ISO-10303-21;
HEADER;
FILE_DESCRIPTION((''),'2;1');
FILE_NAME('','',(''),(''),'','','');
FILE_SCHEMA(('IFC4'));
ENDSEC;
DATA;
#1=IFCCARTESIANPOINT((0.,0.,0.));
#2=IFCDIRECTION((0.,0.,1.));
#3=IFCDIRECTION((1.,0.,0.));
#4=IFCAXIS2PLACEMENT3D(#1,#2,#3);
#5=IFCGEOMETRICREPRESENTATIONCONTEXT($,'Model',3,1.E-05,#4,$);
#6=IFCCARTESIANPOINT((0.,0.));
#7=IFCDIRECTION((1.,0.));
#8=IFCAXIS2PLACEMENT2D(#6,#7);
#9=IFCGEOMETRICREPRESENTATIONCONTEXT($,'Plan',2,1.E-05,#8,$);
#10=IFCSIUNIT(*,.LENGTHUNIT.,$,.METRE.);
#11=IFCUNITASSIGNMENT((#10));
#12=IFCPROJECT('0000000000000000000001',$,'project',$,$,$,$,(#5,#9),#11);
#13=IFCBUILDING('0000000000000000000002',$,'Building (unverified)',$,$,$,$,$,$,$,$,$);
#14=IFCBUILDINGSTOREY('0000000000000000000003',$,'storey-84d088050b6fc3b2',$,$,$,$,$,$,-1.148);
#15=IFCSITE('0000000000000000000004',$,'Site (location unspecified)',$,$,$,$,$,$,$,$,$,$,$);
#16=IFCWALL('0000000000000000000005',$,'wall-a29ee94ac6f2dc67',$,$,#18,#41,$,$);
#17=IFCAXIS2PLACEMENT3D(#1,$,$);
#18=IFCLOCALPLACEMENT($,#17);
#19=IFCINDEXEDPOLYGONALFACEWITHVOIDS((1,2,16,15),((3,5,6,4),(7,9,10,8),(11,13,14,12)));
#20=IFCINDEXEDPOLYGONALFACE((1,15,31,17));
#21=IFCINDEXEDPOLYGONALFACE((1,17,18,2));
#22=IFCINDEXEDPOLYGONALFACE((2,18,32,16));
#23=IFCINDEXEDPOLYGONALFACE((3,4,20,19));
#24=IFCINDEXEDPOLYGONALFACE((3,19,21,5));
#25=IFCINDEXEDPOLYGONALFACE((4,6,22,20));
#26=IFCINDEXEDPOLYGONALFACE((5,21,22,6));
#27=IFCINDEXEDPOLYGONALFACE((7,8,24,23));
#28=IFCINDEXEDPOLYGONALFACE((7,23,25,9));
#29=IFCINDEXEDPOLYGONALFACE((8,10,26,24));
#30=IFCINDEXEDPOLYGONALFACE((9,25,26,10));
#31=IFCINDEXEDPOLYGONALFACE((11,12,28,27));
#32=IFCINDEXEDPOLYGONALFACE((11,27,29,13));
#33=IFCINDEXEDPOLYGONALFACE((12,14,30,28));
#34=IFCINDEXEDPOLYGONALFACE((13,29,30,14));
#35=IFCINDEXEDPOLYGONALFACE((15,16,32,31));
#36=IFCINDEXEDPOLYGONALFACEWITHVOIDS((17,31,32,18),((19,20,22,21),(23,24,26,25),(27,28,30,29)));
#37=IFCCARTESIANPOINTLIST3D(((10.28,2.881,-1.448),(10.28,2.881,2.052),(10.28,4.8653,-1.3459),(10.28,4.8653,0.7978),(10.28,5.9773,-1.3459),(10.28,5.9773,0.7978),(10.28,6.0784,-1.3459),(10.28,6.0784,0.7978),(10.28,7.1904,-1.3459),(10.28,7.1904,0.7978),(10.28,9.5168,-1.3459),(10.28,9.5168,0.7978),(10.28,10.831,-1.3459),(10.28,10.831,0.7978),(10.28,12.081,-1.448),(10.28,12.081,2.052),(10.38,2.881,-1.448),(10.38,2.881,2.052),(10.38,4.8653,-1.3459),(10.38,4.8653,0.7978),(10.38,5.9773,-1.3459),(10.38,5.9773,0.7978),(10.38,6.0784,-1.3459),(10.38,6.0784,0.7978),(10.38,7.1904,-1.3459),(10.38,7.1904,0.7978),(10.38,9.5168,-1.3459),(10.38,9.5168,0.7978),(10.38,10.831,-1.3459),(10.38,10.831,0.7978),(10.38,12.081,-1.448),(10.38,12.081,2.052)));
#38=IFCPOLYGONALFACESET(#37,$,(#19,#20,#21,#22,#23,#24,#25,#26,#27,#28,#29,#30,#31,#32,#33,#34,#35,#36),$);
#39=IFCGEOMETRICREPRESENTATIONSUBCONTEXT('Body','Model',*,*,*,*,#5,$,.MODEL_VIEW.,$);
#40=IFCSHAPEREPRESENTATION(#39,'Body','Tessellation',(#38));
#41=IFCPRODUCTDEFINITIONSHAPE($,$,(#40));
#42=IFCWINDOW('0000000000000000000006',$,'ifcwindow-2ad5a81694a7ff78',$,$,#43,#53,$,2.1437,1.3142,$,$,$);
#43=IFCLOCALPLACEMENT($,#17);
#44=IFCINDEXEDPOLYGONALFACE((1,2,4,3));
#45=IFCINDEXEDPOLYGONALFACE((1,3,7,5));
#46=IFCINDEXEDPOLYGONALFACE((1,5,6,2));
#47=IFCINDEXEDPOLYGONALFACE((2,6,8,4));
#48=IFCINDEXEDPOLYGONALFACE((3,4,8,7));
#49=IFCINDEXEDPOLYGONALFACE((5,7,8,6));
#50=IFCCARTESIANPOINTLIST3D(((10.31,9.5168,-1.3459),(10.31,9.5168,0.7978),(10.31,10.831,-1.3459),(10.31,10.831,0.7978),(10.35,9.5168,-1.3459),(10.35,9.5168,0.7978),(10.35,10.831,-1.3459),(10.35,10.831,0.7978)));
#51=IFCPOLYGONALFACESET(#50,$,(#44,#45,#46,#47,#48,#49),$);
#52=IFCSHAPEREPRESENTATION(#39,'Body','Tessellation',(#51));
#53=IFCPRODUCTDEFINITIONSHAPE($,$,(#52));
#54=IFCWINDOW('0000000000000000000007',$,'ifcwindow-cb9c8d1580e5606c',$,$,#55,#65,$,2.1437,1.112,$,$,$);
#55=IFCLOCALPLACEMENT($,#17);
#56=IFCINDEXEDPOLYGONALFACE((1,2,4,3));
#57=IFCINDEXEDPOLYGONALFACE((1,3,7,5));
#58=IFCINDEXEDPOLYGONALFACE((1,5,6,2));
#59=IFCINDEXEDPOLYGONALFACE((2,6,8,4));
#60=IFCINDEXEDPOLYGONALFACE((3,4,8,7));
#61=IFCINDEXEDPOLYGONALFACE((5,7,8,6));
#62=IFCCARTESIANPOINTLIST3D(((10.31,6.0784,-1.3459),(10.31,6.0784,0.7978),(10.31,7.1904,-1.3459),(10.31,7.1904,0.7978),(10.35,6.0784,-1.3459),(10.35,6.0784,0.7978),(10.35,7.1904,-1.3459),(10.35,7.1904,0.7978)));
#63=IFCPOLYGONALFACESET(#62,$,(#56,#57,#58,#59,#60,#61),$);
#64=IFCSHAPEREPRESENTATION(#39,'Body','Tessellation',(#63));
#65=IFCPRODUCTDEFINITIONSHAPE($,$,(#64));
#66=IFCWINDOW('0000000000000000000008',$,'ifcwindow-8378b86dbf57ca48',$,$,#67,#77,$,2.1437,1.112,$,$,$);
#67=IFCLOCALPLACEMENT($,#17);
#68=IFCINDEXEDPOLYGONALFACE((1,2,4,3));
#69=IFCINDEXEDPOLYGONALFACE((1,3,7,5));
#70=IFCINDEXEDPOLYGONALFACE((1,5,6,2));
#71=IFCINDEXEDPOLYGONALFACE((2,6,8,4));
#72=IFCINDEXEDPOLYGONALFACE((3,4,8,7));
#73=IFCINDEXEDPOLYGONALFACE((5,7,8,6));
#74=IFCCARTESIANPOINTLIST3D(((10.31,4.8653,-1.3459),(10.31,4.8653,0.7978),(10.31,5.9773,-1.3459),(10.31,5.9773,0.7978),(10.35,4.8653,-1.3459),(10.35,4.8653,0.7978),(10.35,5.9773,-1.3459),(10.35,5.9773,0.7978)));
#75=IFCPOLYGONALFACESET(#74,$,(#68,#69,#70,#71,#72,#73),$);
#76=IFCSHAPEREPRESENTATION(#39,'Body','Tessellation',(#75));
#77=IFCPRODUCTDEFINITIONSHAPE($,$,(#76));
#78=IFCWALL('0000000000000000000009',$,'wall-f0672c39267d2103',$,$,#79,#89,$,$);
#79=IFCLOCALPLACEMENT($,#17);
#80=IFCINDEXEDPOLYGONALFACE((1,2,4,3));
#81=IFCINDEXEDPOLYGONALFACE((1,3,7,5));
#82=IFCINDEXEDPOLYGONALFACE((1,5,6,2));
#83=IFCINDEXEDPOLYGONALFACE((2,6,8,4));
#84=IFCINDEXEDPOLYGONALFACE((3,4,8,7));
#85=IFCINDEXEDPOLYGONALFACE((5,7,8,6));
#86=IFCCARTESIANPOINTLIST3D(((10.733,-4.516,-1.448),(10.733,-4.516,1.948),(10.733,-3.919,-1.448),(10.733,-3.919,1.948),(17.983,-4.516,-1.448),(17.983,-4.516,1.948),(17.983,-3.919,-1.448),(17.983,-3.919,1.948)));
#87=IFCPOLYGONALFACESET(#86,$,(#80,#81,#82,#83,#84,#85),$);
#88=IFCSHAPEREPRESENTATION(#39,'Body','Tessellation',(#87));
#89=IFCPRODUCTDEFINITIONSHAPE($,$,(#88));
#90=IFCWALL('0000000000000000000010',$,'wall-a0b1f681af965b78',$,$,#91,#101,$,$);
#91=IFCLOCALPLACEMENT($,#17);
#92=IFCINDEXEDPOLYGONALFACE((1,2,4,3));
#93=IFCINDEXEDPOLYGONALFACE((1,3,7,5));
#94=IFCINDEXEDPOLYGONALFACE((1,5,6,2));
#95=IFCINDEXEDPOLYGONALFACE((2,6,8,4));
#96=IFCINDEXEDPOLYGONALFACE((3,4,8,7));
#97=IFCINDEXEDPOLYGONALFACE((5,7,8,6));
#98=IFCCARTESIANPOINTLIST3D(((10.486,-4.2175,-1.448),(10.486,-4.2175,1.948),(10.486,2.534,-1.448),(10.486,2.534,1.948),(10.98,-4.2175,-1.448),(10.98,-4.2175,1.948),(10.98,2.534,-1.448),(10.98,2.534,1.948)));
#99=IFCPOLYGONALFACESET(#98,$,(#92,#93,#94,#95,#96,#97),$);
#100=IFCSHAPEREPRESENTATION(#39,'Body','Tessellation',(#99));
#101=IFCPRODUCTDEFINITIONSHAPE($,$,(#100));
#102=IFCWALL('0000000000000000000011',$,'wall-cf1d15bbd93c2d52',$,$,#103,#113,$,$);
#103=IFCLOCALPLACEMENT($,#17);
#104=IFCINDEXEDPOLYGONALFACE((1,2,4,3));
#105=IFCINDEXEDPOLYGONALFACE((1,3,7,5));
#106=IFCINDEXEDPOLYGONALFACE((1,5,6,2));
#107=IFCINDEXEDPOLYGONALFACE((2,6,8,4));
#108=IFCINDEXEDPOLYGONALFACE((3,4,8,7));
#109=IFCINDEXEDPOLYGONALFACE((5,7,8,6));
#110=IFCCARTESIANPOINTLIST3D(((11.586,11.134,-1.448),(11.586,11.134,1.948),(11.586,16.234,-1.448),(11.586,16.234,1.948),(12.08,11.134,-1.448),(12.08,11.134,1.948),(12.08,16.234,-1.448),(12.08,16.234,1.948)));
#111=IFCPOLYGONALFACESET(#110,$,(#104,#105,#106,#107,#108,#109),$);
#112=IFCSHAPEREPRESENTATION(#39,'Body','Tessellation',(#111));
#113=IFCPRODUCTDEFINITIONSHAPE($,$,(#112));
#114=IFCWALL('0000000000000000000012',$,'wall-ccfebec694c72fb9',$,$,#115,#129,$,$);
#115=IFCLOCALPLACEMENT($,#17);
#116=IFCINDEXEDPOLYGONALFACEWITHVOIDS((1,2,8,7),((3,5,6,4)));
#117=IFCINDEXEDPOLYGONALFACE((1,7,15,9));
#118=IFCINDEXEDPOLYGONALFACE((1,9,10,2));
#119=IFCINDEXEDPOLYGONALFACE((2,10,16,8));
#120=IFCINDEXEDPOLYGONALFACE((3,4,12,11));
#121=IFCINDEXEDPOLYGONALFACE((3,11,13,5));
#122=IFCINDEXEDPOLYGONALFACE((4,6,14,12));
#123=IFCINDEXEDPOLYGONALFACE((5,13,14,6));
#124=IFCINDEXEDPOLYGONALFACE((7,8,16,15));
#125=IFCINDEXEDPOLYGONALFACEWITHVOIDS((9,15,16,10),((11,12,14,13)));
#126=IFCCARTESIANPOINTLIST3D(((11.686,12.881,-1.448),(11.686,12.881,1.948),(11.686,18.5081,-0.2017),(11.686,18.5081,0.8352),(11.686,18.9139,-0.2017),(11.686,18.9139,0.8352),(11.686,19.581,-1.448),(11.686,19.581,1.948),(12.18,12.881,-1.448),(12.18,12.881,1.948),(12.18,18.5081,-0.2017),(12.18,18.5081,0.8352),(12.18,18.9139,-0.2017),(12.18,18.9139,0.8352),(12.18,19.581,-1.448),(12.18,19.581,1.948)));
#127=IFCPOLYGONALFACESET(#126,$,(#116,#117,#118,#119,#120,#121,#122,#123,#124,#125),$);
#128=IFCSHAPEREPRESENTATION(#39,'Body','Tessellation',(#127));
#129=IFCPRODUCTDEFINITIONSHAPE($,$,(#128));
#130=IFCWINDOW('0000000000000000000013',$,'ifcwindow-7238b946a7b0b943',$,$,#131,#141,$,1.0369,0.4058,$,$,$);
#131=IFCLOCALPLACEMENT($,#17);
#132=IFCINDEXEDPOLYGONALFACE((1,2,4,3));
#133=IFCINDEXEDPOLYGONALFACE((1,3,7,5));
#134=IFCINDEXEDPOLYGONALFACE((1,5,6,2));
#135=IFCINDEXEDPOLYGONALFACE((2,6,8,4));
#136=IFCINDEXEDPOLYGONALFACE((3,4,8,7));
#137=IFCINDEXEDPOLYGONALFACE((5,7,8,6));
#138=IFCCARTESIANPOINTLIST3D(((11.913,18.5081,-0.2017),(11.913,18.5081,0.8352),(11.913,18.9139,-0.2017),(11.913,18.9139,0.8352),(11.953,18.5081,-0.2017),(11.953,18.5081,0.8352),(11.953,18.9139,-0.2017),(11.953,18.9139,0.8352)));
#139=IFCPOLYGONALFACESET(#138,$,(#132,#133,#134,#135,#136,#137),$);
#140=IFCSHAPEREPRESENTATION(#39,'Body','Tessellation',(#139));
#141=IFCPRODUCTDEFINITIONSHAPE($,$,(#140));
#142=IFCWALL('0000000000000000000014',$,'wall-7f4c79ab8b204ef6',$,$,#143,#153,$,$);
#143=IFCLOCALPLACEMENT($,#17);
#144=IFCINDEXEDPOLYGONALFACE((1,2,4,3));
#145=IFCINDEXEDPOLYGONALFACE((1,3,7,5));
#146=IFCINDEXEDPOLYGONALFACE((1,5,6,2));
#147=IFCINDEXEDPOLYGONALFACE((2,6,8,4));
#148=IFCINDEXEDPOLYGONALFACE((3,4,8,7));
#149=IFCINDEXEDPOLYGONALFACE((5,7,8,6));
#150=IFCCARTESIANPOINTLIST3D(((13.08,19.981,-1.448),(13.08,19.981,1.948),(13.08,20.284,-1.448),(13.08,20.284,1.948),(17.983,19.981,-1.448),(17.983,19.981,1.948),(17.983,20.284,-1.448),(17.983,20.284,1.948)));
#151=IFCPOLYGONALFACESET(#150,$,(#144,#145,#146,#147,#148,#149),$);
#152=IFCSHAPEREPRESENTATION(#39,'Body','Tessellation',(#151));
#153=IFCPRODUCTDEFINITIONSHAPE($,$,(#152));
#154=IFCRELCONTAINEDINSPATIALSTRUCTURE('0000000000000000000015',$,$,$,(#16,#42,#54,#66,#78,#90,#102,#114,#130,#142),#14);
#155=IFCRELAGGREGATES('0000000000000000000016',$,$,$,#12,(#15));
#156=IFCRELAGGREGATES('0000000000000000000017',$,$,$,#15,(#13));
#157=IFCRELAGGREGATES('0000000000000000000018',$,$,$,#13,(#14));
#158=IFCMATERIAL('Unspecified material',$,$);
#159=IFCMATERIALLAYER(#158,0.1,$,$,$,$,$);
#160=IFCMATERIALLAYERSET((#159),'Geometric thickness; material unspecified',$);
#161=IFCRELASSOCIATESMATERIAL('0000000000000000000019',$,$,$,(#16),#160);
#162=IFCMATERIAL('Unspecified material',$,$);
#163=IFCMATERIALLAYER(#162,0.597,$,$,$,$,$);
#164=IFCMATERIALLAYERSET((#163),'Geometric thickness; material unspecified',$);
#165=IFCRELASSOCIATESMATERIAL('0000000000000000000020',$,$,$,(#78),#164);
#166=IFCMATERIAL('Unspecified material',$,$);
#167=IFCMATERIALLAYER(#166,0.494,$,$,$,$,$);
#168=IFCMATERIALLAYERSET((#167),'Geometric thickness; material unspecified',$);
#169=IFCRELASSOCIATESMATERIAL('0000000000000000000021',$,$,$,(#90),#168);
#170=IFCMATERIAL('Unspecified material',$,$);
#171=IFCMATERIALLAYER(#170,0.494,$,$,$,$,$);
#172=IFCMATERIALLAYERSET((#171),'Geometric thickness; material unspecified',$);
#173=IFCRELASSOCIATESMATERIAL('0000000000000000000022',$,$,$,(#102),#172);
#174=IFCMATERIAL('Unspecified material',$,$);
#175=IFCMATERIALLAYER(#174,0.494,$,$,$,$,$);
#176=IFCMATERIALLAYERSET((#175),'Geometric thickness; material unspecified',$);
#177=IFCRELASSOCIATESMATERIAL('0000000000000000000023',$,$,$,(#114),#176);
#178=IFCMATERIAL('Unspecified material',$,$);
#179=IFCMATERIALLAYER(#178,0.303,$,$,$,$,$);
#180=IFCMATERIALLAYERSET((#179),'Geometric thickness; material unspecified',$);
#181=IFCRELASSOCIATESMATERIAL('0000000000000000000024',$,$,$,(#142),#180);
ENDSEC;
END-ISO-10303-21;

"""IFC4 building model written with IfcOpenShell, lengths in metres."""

from ifc_helpers import new_model, si_unit, frame, origin_with_axes, origin_2d_with_axis, place, context, subcontext, project, spatial, indexed_curve, outline, extrude, material, layer, layer_set, layer_usage, element, fill, save


model = new_model("IFC4")

# Units and contexts
model_context = context("Model", 3, precision=1e-05, world=origin_with_axes())
plan_context = context("Plan", 2, precision=1e-05, world=origin_2d_with_axis())
body_context = subcontext(model_context, "Body", "Model", "MODEL_VIEW")
ifc_project = project(units=[si_unit("LENGTHUNIT", "METRE")], contexts=[model_context, plan_context])

# Site, building, storey
site = spatial("IfcSite", under=ifc_project, Name="Site (location unspecified)")
building = spatial("IfcBuilding", under=site, Name="Building (unverified)")
storey = spatial("IfcBuildingStorey", under=building, Name="storey-84d088050b6fc3b2", Elevation=-1.148)

# Wall, openings, windows
ifc_material_1 = material(Name="Unspecified material")
ifc_layer_1 = layer(ifc_material_1, 0.1)
ifc_layer_set_1 = layer_set([ifc_layer_1], Name="Geometric thickness; material unspecified")
ifc_layer_usage_1 = layer_usage(ifc_layer_set_1, "AXIS2", "POSITIVE", -0.05)
wall_1_placement = place(None, frame((10.33, 12.081, -1.448), z_axis=(0.0, 0.0, 1.0), x_axis=(0.0, -1.0, 0.0)))
wall_1 = element("IfcWall", 1, at=wall_1_placement, inside=storey, material=ifc_layer_usage_1, Name="wall-a29ee94ac6f2dc67", context=body_context, shape_type="SweptSolid", body=[
    extrude(outline(indexed_curve([(0.0, 0.0), (0.0, 0.1), (9.2, 0.1), (9.2, 0.0), (0.0, 0.0)], self_intersect=False)), frame((0.0, -0.05, 0.0), z_axis=(0.0, 0.0, 1.0), x_axis=(1.0, 0.0, 0.0)), (0.0, 0.0, 1.0), 3.5),
])
opening_1_placement = place(wall_1_placement, frame((1.25, -0.06, 0.1021), z_axis=(0.0, 0.0, 1.0), x_axis=(1.0, 0.0, 0.0)))
opening_1 = element("IfcOpeningElement", 2, at=opening_1_placement, cuts=wall_1, context=body_context, shape_type="SweptSolid", body=[
    extrude(outline(indexed_curve([(0.0, 0.0), (0.0, 0.12), (1.3142, 0.12), (1.3142, 0.0), (0.0, 0.0)], self_intersect=False)), origin_with_axes(), (0.0, 0.0, 1.0), 2.1437),
])
opening_2_placement = place(wall_1_placement, frame((4.8906, -0.06, 0.1021), z_axis=(0.0, 0.0, 1.0), x_axis=(1.0, 0.0, 0.0)))
opening_2 = element("IfcOpeningElement", 3, at=opening_2_placement, cuts=wall_1, context=body_context, shape_type="SweptSolid", body=[
    extrude(outline(indexed_curve([(0.0, 0.0), (0.0, 0.12), (1.112, 0.12), (1.112, 0.0), (0.0, 0.0)], self_intersect=False)), origin_with_axes(), (0.0, 0.0, 1.0), 2.1437),
])
opening_3_placement = place(wall_1_placement, frame((6.1037, -0.06, 0.1021), z_axis=(0.0, 0.0, 1.0), x_axis=(1.0, 0.0, 0.0)))
opening_3 = element("IfcOpeningElement", 4, at=opening_3_placement, cuts=wall_1, context=body_context, shape_type="SweptSolid", body=[
    extrude(outline(indexed_curve([(0.0, 0.0), (0.0, 0.12), (1.112, 0.12), (1.112, 0.0), (0.0, 0.0)], self_intersect=False)), origin_with_axes(), (0.0, 0.0, 1.0), 2.1437),
])
window_1_placement = place(None, frame((10.31, 10.831, -1.3459), z_axis=(0.0, 0.0, 1.0), x_axis=(0.0, -1.0, 0.0)))
window_1 = element("IfcWindow", 5, at=window_1_placement, inside=storey, Name="ifcwindow-2ad5a81694a7ff78", OverallHeight=2.1437, OverallWidth=1.3142, context=body_context, shape_type="SweptSolid", body=[
    extrude(outline(indexed_curve([(0.0, 0.0), (0.0, 0.04), (1.3142, 0.04), (1.3142, 0.0), (0.0, 0.0)], self_intersect=False)), origin_with_axes(), (0.0, 0.0, 1.0), 2.1437),
])
fill(opening_1, window_1)
window_2_placement = place(None, frame((10.31, 7.1904, -1.3459), z_axis=(0.0, 0.0, 1.0), x_axis=(0.0, -1.0, 0.0)))
window_2 = element("IfcWindow", 6, at=window_2_placement, inside=storey, Name="ifcwindow-cb9c8d1580e5606c", OverallHeight=2.1437, OverallWidth=1.112, context=body_context, shape_type="SweptSolid", body=[
    extrude(outline(indexed_curve([(0.0, 0.0), (0.0, 0.04), (1.112, 0.04), (1.112, 0.0), (0.0, 0.0)], self_intersect=False)), origin_with_axes(), (0.0, 0.0, 1.0), 2.1437),
])
fill(opening_2, window_2)
window_3_placement = place(None, frame((10.31, 5.9773, -1.3459), z_axis=(0.0, 0.0, 1.0), x_axis=(0.0, -1.0, 0.0)))
window_3 = element("IfcWindow", 7, at=window_3_placement, inside=storey, Name="ifcwindow-8378b86dbf57ca48", OverallHeight=2.1437, OverallWidth=1.112, context=body_context, shape_type="SweptSolid", body=[
    extrude(outline(indexed_curve([(0.0, 0.0), (0.0, 0.04), (1.112, 0.04), (1.112, 0.0), (0.0, 0.0)], self_intersect=False)), origin_with_axes(), (0.0, 0.0, 1.0), 2.1437),
])
fill(opening_3, window_3)

# Walls
ifc_material_2 = material(Name="Unspecified material")
ifc_layer_2 = layer(ifc_material_2, 0.597)
ifc_layer_set_2 = layer_set([ifc_layer_2], Name="Geometric thickness; material unspecified")
ifc_layer_usage_2 = layer_usage(ifc_layer_set_2, "AXIS2", "POSITIVE", -0.2985)
wall_2_placement = place(None, frame((17.983, -4.2175, -1.448), z_axis=(0.0, 0.0, 1.0), x_axis=(-1.0, 0.0, 0.0)))
element("IfcWall", 8, at=wall_2_placement, inside=storey, material=ifc_layer_usage_2, Name="wall-f0672c39267d2103", context=body_context, shape_type="SweptSolid", body=[
    extrude(outline(indexed_curve([(0.0, 0.0), (0.0, 0.597), (7.25, 0.597), (7.25, 0.0), (0.0, 0.0)], self_intersect=False)), frame((0.0, -0.2985, 0.0), z_axis=(0.0, 0.0, 1.0), x_axis=(1.0, 0.0, 0.0)), (0.0, 0.0, 1.0), 3.396),
])
ifc_material_3 = material(Name="Unspecified material")
ifc_layer_3 = layer(ifc_material_3, 0.494)
ifc_layer_set_3 = layer_set([ifc_layer_3], Name="Geometric thickness; material unspecified")
ifc_layer_usage_3 = layer_usage(ifc_layer_set_3, "AXIS2", "POSITIVE", -0.247)
wall_3_placement = place(None, frame((10.733, -4.2175, -1.448), z_axis=(0.0, 0.0, 1.0), x_axis=(0.0, 1.0, 0.0)))
element("IfcWall", 9, at=wall_3_placement, inside=storey, material=ifc_layer_usage_3, Name="wall-a0b1f681af965b78", context=body_context, shape_type="SweptSolid", body=[
    extrude(outline(indexed_curve([(0.0, 0.0), (0.0, 0.494), (6.7515, 0.494), (6.7515, 0.0), (0.0, 0.0)], self_intersect=False)), frame((0.0, -0.247, 0.0), z_axis=(0.0, 0.0, 1.0), x_axis=(1.0, 0.0, 0.0)), (0.0, 0.0, 1.0), 3.396),
])
ifc_material_4 = material(Name="Unspecified material")
ifc_layer_4 = layer(ifc_material_4, 0.494)
ifc_layer_set_4 = layer_set([ifc_layer_4], Name="Geometric thickness; material unspecified")
ifc_layer_usage_4 = layer_usage(ifc_layer_set_4, "AXIS2", "POSITIVE", -0.247)
wall_4_placement = place(None, frame((11.833, 11.134, -1.448), z_axis=(0.0, 0.0, 1.0), x_axis=(0.0, 1.0, 0.0)))
element("IfcWall", 10, at=wall_4_placement, inside=storey, material=ifc_layer_usage_4, Name="wall-cf1d15bbd93c2d52", context=body_context, shape_type="SweptSolid", body=[
    extrude(outline(indexed_curve([(0.0, 0.0), (0.0, 0.494), (5.1, 0.494), (5.1, 0.0), (0.0, 0.0)], self_intersect=False)), frame((0.0, -0.247, 0.0), z_axis=(0.0, 0.0, 1.0), x_axis=(1.0, 0.0, 0.0)), (0.0, 0.0, 1.0), 3.396),
])

# Wall, opening, window
ifc_material_5 = material(Name="Unspecified material")
ifc_layer_5 = layer(ifc_material_5, 0.494)
ifc_layer_set_5 = layer_set([ifc_layer_5], Name="Geometric thickness; material unspecified")
ifc_layer_usage_5 = layer_usage(ifc_layer_set_5, "AXIS2", "POSITIVE", -0.247)
wall_5_placement = place(None, frame((11.933, 12.881, -1.448), z_axis=(0.0, 0.0, 1.0), x_axis=(0.0, 1.0, 0.0)))
wall_5 = element("IfcWall", 11, at=wall_5_placement, inside=storey, material=ifc_layer_usage_5, Name="wall-ccfebec694c72fb9", context=body_context, shape_type="SweptSolid", body=[
    extrude(outline(indexed_curve([(0.0, 0.0), (0.0, 0.494), (6.7, 0.494), (6.7, 0.0), (0.0, 0.0)], self_intersect=False)), frame((0.0, -0.247, 0.0), z_axis=(0.0, 0.0, 1.0), x_axis=(1.0, 0.0, 0.0)), (0.0, 0.0, 1.0), 3.396),
])
opening_4_placement = place(wall_5_placement, frame((5.6271, -0.257, 1.2463), z_axis=(0.0, 0.0, 1.0), x_axis=(1.0, 0.0, 0.0)))
opening_4 = element("IfcOpeningElement", 12, at=opening_4_placement, cuts=wall_5, context=body_context, shape_type="SweptSolid", body=[
    extrude(outline(indexed_curve([(0.0, 0.0), (0.0, 0.514), (0.4058, 0.514), (0.4058, 0.0), (0.0, 0.0)], self_intersect=False)), origin_with_axes(), (0.0, 0.0, 1.0), 1.0369),
])
window_4_placement = place(None, frame((11.953, 18.5081, -0.2017), z_axis=(0.0, 0.0, 1.0), x_axis=(0.0, 1.0, 0.0)))
window_4 = element("IfcWindow", 13, at=window_4_placement, inside=storey, Name="ifcwindow-7238b946a7b0b943", OverallHeight=1.0369, OverallWidth=0.4058, context=body_context, shape_type="SweptSolid", body=[
    extrude(outline(indexed_curve([(0.0, 0.0), (0.0, 0.04), (0.4058, 0.04), (0.4058, 0.0), (0.0, 0.0)], self_intersect=False)), origin_with_axes(), (0.0, 0.0, 1.0), 1.0369),
])
fill(opening_4, window_4)

# Wall
ifc_material_6 = material(Name="Unspecified material")
ifc_layer_6 = layer(ifc_material_6, 0.303)
ifc_layer_set_6 = layer_set([ifc_layer_6], Name="Geometric thickness; material unspecified")
ifc_layer_usage_6 = layer_usage(ifc_layer_set_6, "AXIS2", "POSITIVE", -0.1515)
wall_6_placement = place(None, frame((13.08, 20.1325, -1.448), z_axis=(0.0, 0.0, 1.0), x_axis=(1.0, 0.0, 0.0)))
element("IfcWall", 14, at=wall_6_placement, inside=storey, material=ifc_layer_usage_6, Name="wall-7f4c79ab8b204ef6", context=body_context, shape_type="SweptSolid", body=[
    extrude(outline(indexed_curve([(0.0, 0.0), (0.0, 0.303), (4.903, 0.303), (4.903, 0.0), (0.0, 0.0)], self_intersect=False)), frame((0.0, -0.1515, 0.0), z_axis=(0.0, 0.0, 1.0), x_axis=(1.0, 0.0, 0.0)), (0.0, 0.0, 1.0), 3.396),
])

save(model, "model.ifc")
